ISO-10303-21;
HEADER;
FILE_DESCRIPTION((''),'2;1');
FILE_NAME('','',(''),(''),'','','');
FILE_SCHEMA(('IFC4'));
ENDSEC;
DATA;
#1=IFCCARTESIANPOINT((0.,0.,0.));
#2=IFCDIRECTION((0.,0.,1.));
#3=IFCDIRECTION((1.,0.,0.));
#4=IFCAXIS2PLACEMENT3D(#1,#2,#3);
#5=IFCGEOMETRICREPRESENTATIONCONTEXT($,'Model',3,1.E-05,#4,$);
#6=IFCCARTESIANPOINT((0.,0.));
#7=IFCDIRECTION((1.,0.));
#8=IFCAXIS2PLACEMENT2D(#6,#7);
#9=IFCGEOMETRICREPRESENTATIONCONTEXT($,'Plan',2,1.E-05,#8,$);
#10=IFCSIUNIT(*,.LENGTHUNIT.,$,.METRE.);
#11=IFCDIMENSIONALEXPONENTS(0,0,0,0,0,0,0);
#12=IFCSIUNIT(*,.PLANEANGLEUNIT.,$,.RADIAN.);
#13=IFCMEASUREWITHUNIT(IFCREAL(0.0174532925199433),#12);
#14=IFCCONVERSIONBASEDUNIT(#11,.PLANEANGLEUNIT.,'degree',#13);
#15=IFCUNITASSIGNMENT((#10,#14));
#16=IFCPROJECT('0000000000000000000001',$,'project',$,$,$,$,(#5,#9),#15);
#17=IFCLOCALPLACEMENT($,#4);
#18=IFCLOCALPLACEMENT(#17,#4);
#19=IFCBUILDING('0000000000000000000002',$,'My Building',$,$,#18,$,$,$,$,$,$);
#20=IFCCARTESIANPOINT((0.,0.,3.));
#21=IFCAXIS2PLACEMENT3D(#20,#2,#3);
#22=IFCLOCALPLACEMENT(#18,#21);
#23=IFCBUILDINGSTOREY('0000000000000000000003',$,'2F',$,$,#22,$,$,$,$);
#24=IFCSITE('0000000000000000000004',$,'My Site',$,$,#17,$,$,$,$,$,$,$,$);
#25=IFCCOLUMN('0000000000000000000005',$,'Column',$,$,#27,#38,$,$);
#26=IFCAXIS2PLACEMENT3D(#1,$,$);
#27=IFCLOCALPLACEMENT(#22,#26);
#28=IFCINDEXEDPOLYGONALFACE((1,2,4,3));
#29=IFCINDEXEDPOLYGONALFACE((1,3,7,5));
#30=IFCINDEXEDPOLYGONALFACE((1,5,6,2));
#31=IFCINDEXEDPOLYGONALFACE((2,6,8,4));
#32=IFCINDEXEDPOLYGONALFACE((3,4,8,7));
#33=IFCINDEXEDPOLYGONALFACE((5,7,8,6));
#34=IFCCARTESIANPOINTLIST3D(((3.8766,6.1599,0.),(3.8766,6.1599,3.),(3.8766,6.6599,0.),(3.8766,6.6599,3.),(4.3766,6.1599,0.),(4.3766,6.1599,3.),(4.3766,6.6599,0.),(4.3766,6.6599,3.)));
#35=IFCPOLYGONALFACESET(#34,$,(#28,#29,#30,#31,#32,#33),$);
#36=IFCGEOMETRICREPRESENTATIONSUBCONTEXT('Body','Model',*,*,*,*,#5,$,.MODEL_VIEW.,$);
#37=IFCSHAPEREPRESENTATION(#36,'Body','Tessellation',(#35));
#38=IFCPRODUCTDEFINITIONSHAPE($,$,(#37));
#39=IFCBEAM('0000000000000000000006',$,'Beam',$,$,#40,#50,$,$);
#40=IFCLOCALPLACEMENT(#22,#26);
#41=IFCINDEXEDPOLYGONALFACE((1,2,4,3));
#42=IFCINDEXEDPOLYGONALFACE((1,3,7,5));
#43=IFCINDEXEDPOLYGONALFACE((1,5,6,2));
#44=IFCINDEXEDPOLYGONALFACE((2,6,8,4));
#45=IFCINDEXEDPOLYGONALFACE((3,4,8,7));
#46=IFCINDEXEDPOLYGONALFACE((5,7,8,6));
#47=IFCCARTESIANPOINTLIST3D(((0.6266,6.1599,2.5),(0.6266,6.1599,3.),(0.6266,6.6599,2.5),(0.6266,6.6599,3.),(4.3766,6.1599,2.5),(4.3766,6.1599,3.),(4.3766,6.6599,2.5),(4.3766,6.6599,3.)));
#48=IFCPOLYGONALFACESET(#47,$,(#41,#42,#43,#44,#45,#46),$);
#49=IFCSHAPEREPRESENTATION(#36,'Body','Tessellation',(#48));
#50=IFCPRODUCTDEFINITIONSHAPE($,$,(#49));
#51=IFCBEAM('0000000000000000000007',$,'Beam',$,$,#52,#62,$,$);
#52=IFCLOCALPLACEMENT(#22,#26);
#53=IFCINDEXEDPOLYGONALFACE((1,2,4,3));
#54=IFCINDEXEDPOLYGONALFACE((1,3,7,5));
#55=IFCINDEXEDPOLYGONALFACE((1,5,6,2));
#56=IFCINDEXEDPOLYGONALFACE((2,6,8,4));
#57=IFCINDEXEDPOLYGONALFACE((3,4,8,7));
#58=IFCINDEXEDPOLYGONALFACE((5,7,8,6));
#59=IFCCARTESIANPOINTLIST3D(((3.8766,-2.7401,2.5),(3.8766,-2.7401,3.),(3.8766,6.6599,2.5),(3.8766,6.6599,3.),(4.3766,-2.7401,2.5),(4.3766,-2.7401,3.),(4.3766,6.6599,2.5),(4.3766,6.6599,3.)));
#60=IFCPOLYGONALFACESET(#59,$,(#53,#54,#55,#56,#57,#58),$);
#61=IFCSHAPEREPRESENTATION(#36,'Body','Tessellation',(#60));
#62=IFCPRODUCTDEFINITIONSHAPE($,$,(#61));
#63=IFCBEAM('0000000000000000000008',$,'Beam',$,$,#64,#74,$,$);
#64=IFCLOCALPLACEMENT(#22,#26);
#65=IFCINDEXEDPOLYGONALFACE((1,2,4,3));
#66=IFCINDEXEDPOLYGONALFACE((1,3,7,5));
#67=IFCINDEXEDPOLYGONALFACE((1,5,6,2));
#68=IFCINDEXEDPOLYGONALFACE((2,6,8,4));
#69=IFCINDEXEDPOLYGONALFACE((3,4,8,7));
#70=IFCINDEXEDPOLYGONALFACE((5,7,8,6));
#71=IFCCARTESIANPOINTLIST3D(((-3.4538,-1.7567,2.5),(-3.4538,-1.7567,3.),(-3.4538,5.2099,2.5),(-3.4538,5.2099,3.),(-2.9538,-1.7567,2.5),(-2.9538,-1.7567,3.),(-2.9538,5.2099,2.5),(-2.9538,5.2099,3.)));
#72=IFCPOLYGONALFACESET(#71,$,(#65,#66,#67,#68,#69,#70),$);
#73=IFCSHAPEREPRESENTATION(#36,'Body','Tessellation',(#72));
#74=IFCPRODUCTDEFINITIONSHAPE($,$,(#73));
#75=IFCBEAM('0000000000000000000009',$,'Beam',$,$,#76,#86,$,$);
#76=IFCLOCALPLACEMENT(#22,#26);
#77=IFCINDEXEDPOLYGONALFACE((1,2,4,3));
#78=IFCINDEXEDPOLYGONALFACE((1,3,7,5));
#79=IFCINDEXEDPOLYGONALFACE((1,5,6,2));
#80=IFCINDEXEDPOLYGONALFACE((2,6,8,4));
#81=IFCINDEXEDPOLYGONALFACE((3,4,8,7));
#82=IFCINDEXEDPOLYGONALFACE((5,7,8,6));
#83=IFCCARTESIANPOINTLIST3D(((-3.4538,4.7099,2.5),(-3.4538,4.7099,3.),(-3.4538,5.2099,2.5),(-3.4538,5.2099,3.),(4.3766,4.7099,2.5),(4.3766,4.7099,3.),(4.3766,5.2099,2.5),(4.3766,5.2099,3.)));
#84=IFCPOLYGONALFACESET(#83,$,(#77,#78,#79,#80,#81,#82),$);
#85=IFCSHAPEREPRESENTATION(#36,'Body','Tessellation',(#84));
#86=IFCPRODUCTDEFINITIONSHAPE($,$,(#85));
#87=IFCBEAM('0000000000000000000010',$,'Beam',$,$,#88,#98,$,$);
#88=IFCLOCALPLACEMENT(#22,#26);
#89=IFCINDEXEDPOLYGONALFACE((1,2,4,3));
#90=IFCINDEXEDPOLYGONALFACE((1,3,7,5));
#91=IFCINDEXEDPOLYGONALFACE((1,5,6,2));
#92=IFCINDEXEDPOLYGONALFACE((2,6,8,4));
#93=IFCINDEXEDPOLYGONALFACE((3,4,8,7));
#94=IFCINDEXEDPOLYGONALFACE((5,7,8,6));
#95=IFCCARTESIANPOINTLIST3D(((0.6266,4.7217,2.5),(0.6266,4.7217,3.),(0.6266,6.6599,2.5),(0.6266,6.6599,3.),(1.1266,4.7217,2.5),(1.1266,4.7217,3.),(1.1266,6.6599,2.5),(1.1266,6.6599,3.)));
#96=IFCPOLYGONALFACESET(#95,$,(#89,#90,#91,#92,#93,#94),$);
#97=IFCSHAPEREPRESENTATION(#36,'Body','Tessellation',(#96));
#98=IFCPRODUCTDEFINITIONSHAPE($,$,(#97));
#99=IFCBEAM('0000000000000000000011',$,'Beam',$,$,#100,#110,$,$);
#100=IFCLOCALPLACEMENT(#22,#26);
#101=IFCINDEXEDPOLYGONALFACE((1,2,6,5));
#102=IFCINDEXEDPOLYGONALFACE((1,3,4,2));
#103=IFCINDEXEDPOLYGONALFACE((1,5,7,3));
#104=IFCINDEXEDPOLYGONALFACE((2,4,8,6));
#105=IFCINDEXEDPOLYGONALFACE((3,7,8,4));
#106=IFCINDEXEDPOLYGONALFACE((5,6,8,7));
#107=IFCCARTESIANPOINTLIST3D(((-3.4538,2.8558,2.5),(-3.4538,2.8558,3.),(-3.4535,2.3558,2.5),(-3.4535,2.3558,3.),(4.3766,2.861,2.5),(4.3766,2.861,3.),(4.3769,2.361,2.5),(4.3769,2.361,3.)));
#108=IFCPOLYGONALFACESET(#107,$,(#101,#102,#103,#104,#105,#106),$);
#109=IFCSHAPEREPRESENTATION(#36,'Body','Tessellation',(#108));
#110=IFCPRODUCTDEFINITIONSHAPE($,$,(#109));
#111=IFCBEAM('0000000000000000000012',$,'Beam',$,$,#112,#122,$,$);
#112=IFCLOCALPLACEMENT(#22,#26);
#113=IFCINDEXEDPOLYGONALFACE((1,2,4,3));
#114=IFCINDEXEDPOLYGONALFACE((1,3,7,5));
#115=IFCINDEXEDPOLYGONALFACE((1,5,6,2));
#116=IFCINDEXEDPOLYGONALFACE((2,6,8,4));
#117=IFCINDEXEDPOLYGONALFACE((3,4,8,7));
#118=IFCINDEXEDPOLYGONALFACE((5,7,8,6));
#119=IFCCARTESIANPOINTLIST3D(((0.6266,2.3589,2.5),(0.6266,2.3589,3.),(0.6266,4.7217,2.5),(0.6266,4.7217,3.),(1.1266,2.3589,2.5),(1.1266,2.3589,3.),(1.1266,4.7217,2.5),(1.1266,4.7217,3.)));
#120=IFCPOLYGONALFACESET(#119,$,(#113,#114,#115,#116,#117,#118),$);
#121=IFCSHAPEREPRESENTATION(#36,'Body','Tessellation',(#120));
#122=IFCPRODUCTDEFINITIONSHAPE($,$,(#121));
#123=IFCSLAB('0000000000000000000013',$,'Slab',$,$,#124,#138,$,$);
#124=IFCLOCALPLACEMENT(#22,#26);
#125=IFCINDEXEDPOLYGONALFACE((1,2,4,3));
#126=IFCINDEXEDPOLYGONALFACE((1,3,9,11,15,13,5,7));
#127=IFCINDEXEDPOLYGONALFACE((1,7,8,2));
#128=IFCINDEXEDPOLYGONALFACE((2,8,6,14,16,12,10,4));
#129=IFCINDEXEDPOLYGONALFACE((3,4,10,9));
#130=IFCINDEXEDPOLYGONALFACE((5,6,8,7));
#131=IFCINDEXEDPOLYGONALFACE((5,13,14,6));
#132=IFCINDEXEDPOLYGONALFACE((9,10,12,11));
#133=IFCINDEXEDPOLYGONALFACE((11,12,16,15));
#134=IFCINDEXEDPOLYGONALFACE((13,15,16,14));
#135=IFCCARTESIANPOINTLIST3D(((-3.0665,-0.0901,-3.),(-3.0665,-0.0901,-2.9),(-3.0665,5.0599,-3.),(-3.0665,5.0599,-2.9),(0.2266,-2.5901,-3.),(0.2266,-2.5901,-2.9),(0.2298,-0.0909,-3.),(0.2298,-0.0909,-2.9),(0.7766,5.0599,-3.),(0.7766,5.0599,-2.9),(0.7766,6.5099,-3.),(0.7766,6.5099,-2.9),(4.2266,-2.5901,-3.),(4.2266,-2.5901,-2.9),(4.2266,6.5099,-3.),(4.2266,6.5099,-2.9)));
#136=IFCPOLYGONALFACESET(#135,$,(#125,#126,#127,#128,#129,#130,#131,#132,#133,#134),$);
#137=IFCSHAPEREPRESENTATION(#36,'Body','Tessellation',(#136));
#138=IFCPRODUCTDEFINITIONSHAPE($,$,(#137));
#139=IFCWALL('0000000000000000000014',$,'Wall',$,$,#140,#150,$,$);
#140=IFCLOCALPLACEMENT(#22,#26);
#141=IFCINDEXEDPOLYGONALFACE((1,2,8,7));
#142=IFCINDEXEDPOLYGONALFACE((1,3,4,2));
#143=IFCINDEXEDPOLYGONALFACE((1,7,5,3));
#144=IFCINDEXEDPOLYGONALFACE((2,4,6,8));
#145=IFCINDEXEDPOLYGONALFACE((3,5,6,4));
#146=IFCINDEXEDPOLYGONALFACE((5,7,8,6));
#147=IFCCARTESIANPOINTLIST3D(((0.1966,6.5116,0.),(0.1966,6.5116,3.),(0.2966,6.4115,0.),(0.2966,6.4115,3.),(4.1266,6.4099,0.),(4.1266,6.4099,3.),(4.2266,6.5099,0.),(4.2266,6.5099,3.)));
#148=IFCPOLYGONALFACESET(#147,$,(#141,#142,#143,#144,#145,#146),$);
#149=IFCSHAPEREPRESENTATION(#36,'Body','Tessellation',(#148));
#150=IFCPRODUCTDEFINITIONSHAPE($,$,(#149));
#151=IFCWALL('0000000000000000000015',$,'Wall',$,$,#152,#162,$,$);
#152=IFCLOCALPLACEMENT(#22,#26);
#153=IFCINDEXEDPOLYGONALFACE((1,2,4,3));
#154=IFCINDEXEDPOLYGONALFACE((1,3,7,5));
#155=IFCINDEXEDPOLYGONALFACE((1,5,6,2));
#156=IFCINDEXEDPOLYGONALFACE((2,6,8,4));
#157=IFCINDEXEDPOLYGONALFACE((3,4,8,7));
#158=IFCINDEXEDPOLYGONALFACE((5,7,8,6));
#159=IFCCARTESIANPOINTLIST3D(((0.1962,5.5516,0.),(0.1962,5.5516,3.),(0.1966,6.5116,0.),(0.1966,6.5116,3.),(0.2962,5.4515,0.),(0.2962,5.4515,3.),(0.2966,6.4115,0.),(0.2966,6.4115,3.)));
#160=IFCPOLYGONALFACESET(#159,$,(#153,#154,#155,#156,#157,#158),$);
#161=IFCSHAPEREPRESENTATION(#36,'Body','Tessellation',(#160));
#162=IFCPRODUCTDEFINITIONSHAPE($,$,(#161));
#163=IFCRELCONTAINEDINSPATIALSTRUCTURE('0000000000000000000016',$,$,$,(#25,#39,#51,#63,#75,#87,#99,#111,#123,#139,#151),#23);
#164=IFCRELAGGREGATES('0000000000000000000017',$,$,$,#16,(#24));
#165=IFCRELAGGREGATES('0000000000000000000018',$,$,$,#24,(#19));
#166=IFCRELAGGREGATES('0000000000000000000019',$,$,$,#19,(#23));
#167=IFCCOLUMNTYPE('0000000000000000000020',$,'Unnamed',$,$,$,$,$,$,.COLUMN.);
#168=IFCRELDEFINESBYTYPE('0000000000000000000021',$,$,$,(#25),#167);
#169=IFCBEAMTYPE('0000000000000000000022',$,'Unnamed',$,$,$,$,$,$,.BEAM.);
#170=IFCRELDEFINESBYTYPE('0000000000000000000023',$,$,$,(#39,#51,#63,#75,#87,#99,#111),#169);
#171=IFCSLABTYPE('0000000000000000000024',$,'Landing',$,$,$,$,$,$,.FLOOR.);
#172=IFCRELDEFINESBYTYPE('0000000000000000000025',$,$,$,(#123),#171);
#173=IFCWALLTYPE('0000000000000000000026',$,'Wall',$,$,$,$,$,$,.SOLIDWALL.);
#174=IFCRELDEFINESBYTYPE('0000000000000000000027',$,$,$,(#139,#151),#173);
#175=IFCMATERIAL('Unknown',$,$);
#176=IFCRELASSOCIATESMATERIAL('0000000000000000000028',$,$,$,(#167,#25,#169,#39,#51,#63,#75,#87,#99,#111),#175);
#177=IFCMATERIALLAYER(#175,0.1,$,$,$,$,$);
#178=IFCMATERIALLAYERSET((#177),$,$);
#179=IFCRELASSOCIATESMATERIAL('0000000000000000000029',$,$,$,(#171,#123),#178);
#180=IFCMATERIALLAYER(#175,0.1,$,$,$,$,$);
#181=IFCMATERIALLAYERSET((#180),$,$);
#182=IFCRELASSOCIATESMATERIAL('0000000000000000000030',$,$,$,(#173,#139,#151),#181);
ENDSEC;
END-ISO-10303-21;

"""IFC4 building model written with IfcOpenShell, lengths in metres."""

from ifc_helpers import new_model, entity, si_unit, converted_unit, frame, origin_with_axes, origin_2d_with_axis, place, context, subcontext, project, spatial, line, indexed_curve, rectangle, outline, extrude, material, layer, layer_set, layer_usage, material_profile, profile_set, profile_usage, type_object, element, save


model = new_model("IFC4")

# Units and contexts
model_context = context("Model", 3, precision=1e-05, world=origin_with_axes())
plan_context = context("Plan", 2, precision=1e-05, world=origin_2d_with_axis())
body_context_1 = subcontext(model_context, "Body", "Model", "MODEL_VIEW")
ifc_project = project(units=[si_unit("LENGTHUNIT", "METRE"), converted_unit("PLANEANGLEUNIT", "degree", entity("IfcReal", 0.0174532925199433), si_unit("PLANEANGLEUNIT", "RADIAN"), dimensions=[0, 0, 0, 0, 0, 0, 0])], contexts=[model_context, plan_context])

# Site, building, storey
site_placement = place(None, origin_with_axes())
site = spatial("IfcSite", under=ifc_project, at=site_placement, Name="My Site")
building_placement = place(site_placement, origin_with_axes())
building = spatial("IfcBuilding", under=site, at=building_placement, Name="My Building")
storey_placement = place(building_placement, frame((0.0, 0.0, 3.0), z_axis=(0.0, 0.0, 1.0), x_axis=(1.0, 0.0, 0.0)))
storey = spatial("IfcBuildingStorey", under=building, at=storey_placement, Name="2F")

# Column
ifc_material = material(Name="Unknown")
ifc_material_profile_1 = material_profile(ifc_material, rectangle(XDim=0.5, YDim=0.5))
ifc_profile_set_1 = profile_set([ifc_material_profile_1])
ifc_profile_usage_1 = profile_usage(ifc_profile_set_1, cardinal=5)
column_type = type_object("IfcColumnType", Name="Unnamed", PredefinedType="COLUMN", material=ifc_profile_set_1)
column_placement = place(storey_placement, frame((4.1266, 6.4099, 0.0), z_axis=(0.0, 0.0, 1.0), x_axis=(1.0, 0.0, 0.0)))
element("IfcColumn", 1, at=column_placement, inside=storey, type_object=column_type, material=ifc_profile_usage_1, Name="Column", context=body_context_1, shape_type="SweptSolid", body=[
    extrude(rectangle(XDim=0.5, YDim=0.5), origin_with_axes(), (0.0, 0.0, 1.0), 3.0),
])

# Beams
ifc_material_profile_2 = material_profile(ifc_material, rectangle(XDim=0.5, YDim=0.5))
ifc_profile_set_2 = profile_set([ifc_material_profile_2])
ifc_profile_usage_2 = profile_usage(ifc_profile_set_2, cardinal=7)
beam_type = type_object("IfcBeamType", Name="Unnamed", PredefinedType="BEAM", material=ifc_profile_set_2)
beam_1_placement = place(storey_placement, frame((0.6266, 6.6599, 3.0), z_axis=(1.0, 0.000011, 0.0), x_axis=(-0.000011, 1.0, 0.0)))
element("IfcBeam", 2, at=beam_1_placement, inside=storey, type_object=beam_type, material=ifc_profile_usage_2, Name="Beam", context=body_context_1, shape_type="SweptSolid", body=[
    extrude(rectangle(XDim=0.5, YDim=0.5), frame((-0.25, -0.25, 0.0), z_axis=(0.0, 0.0, 1.0), x_axis=(1.0, 0.0, 0.0)), (0.0, 0.0, 1.0), 3.75),
])
ifc_profile_usage_3 = profile_usage(ifc_profile_set_2, cardinal=7)
beam_2_placement = place(storey_placement, frame((4.3766, 6.6599, 3.0), z_axis=(0.000005, -1.0, 0.0), x_axis=(1.0, 0.000005, 0.0)))
element("IfcBeam", 3, at=beam_2_placement, inside=storey, type_object=beam_type, material=ifc_profile_usage_3, Name="Beam", context=body_context_1, shape_type="SweptSolid", body=[
    extrude(rectangle(XDim=0.5, YDim=0.5), frame((-0.25, -0.25, 0.0), z_axis=(0.0, 0.0, 1.0), x_axis=(1.0, 0.0, 0.0)), (0.0, 0.0, 1.0), 9.4),
])
ifc_profile_usage_4 = profile_usage(ifc_profile_set_2, cardinal=7)
beam_3_placement = place(storey_placement, frame((-2.9538, 5.2099, 3.0), z_axis=(0.0, -1.0, 0.0), x_axis=(1.0, 0.0, 0.0)))
element("IfcBeam", 4, at=beam_3_placement, inside=storey, type_object=beam_type, material=ifc_profile_usage_4, Name="Beam", context=body_context_1, shape_type="SweptSolid", body=[
    extrude(rectangle(XDim=0.5, YDim=0.5), frame((-0.25, -0.25, 0.0), z_axis=(0.0, 0.0, 1.0), x_axis=(1.0, 0.0, 0.0)), (0.0, 0.0, 1.0), 6.9666),
])
ifc_profile_usage_5 = profile_usage(ifc_profile_set_2, cardinal=7)
beam_4_placement = place(storey_placement, frame((-3.4538, 5.2099, 3.0), z_axis=(1.0, 0.0, 0.0), x_axis=(0.0, 1.0, 0.0)))
element("IfcBeam", 5, at=beam_4_placement, inside=storey, type_object=beam_type, material=ifc_profile_usage_5, Name="Beam", context=body_context_1, shape_type="SweptSolid", body=[
    extrude(rectangle(XDim=0.5, YDim=0.5), frame((-0.25, -0.25, 0.0), z_axis=(0.0, 0.0, 1.0), x_axis=(1.0, 0.0, 0.0)), (0.0, 0.0, 1.0), 7.8305),
])
ifc_profile_usage_6 = profile_usage(ifc_profile_set_2, cardinal=7)
beam_5_placement = place(storey_placement, frame((1.1266, 6.6599, 3.0), z_axis=(0.0, -1.0, 0.0), x_axis=(1.0, 0.0, 0.0)))
element("IfcBeam", 6, at=beam_5_placement, inside=storey, type_object=beam_type, material=ifc_profile_usage_6, Name="Beam", context=body_context_1, shape_type="SweptSolid", body=[
    extrude(rectangle(XDim=0.5, YDim=0.5), frame((-0.25, -0.25, 0.0), z_axis=(0.0, 0.0, 1.0), x_axis=(1.0, 0.0, 0.0)), (0.0, 0.0, 1.0), 1.9382),
])
ifc_profile_usage_7 = profile_usage(ifc_profile_set_2, cardinal=7)
beam_6_placement = place(storey_placement, frame((-3.4538, 2.8558, 3.0), z_axis=(1.0, 0.000667, 0.0), x_axis=(-0.000667, 1.0, 0.0)))
element("IfcBeam", 7, at=beam_6_placement, inside=storey, type_object=beam_type, material=ifc_profile_usage_7, Name="Beam", context=body_context_1, shape_type="SweptSolid", body=[
    extrude(rectangle(XDim=0.5, YDim=0.5), frame((-0.25, -0.25, 0.0), z_axis=(0.0, 0.0, 1.0), x_axis=(1.0, 0.0, 0.0)), (0.0, 0.0, 1.0), 7.8304),
])
ifc_profile_usage_8 = profile_usage(ifc_profile_set_2, cardinal=7)
beam_7_placement = place(storey_placement, frame((1.1266, 4.7217, 3.0), z_axis=(0.0, -1.0, 0.0), x_axis=(1.0, 0.0, 0.0)))
element("IfcBeam", 8, at=beam_7_placement, inside=storey, type_object=beam_type, material=ifc_profile_usage_8, Name="Beam", context=body_context_1, shape_type="SweptSolid", body=[
    extrude(rectangle(XDim=0.5, YDim=0.5), frame((-0.25, -0.25, 0.0), z_axis=(0.0, 0.0, 1.0), x_axis=(1.0, 0.0, 0.0)), (0.0, 0.0, 1.0), 2.3628),
])

# Slab
ifc_layer_1 = layer(ifc_material, 0.1)
ifc_layer_set_1 = layer_set([ifc_layer_1])
ifc_layer_usage_1 = layer_usage(ifc_layer_set_1, "AXIS3", "POSITIVE", -0.1)
slab_type = type_object("IfcSlabType", Name="Landing", PredefinedType="FLOOR", material=ifc_layer_set_1)
slab_placement = place(storey_placement, frame((4.2266, 6.5099, -2.9), z_axis=(0.0, 0.0, 1.0), x_axis=(1.0, 0.0, 0.0)))
element("IfcSlab", 9, at=slab_placement, inside=storey, type_object=slab_type, material=ifc_layer_usage_1, Name="Slab", context=body_context_1, shape_type="SweptSolid", body=[
    extrude(outline(indexed_curve([(0.0, 0.0), (-3.45, 0.0), (-3.45, -1.45), (-7.2931, -1.45), (-7.2931, -6.6), (-3.9968, -6.6008), (-4.0, -9.1), (0.0, -9.1), (0.0, 0.0)])), frame((0.0, 0.0, -0.1), z_axis=(0.0, 0.0, 1.0), x_axis=(1.0, 0.0, 0.0)), (0.0, 0.0, 1.0), 0.1),
])

# Walls
ifc_layer_2 = layer(ifc_material, 0.1)
ifc_layer_set_2 = layer_set([ifc_layer_2])
ifc_layer_usage_2 = layer_usage(ifc_layer_set_2, "AXIS2", "POSITIVE", 0.0)
wall_type = type_object("IfcWallType", Name="Wall", PredefinedType="SOLIDWALL", material=ifc_layer_set_2)
wall_1_placement = place(storey_placement, frame((4.2266, 6.5099, 0.0), z_axis=(0.0, 0.0, 1.0), x_axis=(-1.0, 0.000415, 0.0)))
element("IfcWall", 10, at=wall_1_placement, inside=storey, type_object=wall_type, material=ifc_layer_usage_2, Name="Wall", context=body_context_1, shape_type="SweptSolid", body=[
    extrude(outline(indexed_curve([(0.0, 0.0), (0.1, 0.1), (3.93, 0.1), (4.03, 0.0)], segments=[line(1, 2, 3, 4, 1)])), origin_with_axes(), (0.0, 0.0, 1.0), 3.0),
])
ifc_layer_usage_3 = layer_usage(ifc_layer_set_2, "AXIS2", "POSITIVE", 0.0)
wall_2_placement = place(storey_placement, frame((0.1966, 6.5116, 0.0), z_axis=(0.0, 0.0, 1.0), x_axis=(-0.000415, -1.0, 0.0)))
element("IfcWall", 11, at=wall_2_placement, inside=storey, type_object=wall_type, material=ifc_layer_usage_3, Name="Wall", context=body_context_1, shape_type="SweptSolid", body=[
    extrude(outline(indexed_curve([(0.0, 0.0), (0.1, 0.1), (1.06, 0.1), (0.96, 0.0)], segments=[line(1, 2, 3, 4, 1)])), origin_with_axes(), (0.0, 0.0, 1.0), 3.0),
])

save(model, "model.ifc")
